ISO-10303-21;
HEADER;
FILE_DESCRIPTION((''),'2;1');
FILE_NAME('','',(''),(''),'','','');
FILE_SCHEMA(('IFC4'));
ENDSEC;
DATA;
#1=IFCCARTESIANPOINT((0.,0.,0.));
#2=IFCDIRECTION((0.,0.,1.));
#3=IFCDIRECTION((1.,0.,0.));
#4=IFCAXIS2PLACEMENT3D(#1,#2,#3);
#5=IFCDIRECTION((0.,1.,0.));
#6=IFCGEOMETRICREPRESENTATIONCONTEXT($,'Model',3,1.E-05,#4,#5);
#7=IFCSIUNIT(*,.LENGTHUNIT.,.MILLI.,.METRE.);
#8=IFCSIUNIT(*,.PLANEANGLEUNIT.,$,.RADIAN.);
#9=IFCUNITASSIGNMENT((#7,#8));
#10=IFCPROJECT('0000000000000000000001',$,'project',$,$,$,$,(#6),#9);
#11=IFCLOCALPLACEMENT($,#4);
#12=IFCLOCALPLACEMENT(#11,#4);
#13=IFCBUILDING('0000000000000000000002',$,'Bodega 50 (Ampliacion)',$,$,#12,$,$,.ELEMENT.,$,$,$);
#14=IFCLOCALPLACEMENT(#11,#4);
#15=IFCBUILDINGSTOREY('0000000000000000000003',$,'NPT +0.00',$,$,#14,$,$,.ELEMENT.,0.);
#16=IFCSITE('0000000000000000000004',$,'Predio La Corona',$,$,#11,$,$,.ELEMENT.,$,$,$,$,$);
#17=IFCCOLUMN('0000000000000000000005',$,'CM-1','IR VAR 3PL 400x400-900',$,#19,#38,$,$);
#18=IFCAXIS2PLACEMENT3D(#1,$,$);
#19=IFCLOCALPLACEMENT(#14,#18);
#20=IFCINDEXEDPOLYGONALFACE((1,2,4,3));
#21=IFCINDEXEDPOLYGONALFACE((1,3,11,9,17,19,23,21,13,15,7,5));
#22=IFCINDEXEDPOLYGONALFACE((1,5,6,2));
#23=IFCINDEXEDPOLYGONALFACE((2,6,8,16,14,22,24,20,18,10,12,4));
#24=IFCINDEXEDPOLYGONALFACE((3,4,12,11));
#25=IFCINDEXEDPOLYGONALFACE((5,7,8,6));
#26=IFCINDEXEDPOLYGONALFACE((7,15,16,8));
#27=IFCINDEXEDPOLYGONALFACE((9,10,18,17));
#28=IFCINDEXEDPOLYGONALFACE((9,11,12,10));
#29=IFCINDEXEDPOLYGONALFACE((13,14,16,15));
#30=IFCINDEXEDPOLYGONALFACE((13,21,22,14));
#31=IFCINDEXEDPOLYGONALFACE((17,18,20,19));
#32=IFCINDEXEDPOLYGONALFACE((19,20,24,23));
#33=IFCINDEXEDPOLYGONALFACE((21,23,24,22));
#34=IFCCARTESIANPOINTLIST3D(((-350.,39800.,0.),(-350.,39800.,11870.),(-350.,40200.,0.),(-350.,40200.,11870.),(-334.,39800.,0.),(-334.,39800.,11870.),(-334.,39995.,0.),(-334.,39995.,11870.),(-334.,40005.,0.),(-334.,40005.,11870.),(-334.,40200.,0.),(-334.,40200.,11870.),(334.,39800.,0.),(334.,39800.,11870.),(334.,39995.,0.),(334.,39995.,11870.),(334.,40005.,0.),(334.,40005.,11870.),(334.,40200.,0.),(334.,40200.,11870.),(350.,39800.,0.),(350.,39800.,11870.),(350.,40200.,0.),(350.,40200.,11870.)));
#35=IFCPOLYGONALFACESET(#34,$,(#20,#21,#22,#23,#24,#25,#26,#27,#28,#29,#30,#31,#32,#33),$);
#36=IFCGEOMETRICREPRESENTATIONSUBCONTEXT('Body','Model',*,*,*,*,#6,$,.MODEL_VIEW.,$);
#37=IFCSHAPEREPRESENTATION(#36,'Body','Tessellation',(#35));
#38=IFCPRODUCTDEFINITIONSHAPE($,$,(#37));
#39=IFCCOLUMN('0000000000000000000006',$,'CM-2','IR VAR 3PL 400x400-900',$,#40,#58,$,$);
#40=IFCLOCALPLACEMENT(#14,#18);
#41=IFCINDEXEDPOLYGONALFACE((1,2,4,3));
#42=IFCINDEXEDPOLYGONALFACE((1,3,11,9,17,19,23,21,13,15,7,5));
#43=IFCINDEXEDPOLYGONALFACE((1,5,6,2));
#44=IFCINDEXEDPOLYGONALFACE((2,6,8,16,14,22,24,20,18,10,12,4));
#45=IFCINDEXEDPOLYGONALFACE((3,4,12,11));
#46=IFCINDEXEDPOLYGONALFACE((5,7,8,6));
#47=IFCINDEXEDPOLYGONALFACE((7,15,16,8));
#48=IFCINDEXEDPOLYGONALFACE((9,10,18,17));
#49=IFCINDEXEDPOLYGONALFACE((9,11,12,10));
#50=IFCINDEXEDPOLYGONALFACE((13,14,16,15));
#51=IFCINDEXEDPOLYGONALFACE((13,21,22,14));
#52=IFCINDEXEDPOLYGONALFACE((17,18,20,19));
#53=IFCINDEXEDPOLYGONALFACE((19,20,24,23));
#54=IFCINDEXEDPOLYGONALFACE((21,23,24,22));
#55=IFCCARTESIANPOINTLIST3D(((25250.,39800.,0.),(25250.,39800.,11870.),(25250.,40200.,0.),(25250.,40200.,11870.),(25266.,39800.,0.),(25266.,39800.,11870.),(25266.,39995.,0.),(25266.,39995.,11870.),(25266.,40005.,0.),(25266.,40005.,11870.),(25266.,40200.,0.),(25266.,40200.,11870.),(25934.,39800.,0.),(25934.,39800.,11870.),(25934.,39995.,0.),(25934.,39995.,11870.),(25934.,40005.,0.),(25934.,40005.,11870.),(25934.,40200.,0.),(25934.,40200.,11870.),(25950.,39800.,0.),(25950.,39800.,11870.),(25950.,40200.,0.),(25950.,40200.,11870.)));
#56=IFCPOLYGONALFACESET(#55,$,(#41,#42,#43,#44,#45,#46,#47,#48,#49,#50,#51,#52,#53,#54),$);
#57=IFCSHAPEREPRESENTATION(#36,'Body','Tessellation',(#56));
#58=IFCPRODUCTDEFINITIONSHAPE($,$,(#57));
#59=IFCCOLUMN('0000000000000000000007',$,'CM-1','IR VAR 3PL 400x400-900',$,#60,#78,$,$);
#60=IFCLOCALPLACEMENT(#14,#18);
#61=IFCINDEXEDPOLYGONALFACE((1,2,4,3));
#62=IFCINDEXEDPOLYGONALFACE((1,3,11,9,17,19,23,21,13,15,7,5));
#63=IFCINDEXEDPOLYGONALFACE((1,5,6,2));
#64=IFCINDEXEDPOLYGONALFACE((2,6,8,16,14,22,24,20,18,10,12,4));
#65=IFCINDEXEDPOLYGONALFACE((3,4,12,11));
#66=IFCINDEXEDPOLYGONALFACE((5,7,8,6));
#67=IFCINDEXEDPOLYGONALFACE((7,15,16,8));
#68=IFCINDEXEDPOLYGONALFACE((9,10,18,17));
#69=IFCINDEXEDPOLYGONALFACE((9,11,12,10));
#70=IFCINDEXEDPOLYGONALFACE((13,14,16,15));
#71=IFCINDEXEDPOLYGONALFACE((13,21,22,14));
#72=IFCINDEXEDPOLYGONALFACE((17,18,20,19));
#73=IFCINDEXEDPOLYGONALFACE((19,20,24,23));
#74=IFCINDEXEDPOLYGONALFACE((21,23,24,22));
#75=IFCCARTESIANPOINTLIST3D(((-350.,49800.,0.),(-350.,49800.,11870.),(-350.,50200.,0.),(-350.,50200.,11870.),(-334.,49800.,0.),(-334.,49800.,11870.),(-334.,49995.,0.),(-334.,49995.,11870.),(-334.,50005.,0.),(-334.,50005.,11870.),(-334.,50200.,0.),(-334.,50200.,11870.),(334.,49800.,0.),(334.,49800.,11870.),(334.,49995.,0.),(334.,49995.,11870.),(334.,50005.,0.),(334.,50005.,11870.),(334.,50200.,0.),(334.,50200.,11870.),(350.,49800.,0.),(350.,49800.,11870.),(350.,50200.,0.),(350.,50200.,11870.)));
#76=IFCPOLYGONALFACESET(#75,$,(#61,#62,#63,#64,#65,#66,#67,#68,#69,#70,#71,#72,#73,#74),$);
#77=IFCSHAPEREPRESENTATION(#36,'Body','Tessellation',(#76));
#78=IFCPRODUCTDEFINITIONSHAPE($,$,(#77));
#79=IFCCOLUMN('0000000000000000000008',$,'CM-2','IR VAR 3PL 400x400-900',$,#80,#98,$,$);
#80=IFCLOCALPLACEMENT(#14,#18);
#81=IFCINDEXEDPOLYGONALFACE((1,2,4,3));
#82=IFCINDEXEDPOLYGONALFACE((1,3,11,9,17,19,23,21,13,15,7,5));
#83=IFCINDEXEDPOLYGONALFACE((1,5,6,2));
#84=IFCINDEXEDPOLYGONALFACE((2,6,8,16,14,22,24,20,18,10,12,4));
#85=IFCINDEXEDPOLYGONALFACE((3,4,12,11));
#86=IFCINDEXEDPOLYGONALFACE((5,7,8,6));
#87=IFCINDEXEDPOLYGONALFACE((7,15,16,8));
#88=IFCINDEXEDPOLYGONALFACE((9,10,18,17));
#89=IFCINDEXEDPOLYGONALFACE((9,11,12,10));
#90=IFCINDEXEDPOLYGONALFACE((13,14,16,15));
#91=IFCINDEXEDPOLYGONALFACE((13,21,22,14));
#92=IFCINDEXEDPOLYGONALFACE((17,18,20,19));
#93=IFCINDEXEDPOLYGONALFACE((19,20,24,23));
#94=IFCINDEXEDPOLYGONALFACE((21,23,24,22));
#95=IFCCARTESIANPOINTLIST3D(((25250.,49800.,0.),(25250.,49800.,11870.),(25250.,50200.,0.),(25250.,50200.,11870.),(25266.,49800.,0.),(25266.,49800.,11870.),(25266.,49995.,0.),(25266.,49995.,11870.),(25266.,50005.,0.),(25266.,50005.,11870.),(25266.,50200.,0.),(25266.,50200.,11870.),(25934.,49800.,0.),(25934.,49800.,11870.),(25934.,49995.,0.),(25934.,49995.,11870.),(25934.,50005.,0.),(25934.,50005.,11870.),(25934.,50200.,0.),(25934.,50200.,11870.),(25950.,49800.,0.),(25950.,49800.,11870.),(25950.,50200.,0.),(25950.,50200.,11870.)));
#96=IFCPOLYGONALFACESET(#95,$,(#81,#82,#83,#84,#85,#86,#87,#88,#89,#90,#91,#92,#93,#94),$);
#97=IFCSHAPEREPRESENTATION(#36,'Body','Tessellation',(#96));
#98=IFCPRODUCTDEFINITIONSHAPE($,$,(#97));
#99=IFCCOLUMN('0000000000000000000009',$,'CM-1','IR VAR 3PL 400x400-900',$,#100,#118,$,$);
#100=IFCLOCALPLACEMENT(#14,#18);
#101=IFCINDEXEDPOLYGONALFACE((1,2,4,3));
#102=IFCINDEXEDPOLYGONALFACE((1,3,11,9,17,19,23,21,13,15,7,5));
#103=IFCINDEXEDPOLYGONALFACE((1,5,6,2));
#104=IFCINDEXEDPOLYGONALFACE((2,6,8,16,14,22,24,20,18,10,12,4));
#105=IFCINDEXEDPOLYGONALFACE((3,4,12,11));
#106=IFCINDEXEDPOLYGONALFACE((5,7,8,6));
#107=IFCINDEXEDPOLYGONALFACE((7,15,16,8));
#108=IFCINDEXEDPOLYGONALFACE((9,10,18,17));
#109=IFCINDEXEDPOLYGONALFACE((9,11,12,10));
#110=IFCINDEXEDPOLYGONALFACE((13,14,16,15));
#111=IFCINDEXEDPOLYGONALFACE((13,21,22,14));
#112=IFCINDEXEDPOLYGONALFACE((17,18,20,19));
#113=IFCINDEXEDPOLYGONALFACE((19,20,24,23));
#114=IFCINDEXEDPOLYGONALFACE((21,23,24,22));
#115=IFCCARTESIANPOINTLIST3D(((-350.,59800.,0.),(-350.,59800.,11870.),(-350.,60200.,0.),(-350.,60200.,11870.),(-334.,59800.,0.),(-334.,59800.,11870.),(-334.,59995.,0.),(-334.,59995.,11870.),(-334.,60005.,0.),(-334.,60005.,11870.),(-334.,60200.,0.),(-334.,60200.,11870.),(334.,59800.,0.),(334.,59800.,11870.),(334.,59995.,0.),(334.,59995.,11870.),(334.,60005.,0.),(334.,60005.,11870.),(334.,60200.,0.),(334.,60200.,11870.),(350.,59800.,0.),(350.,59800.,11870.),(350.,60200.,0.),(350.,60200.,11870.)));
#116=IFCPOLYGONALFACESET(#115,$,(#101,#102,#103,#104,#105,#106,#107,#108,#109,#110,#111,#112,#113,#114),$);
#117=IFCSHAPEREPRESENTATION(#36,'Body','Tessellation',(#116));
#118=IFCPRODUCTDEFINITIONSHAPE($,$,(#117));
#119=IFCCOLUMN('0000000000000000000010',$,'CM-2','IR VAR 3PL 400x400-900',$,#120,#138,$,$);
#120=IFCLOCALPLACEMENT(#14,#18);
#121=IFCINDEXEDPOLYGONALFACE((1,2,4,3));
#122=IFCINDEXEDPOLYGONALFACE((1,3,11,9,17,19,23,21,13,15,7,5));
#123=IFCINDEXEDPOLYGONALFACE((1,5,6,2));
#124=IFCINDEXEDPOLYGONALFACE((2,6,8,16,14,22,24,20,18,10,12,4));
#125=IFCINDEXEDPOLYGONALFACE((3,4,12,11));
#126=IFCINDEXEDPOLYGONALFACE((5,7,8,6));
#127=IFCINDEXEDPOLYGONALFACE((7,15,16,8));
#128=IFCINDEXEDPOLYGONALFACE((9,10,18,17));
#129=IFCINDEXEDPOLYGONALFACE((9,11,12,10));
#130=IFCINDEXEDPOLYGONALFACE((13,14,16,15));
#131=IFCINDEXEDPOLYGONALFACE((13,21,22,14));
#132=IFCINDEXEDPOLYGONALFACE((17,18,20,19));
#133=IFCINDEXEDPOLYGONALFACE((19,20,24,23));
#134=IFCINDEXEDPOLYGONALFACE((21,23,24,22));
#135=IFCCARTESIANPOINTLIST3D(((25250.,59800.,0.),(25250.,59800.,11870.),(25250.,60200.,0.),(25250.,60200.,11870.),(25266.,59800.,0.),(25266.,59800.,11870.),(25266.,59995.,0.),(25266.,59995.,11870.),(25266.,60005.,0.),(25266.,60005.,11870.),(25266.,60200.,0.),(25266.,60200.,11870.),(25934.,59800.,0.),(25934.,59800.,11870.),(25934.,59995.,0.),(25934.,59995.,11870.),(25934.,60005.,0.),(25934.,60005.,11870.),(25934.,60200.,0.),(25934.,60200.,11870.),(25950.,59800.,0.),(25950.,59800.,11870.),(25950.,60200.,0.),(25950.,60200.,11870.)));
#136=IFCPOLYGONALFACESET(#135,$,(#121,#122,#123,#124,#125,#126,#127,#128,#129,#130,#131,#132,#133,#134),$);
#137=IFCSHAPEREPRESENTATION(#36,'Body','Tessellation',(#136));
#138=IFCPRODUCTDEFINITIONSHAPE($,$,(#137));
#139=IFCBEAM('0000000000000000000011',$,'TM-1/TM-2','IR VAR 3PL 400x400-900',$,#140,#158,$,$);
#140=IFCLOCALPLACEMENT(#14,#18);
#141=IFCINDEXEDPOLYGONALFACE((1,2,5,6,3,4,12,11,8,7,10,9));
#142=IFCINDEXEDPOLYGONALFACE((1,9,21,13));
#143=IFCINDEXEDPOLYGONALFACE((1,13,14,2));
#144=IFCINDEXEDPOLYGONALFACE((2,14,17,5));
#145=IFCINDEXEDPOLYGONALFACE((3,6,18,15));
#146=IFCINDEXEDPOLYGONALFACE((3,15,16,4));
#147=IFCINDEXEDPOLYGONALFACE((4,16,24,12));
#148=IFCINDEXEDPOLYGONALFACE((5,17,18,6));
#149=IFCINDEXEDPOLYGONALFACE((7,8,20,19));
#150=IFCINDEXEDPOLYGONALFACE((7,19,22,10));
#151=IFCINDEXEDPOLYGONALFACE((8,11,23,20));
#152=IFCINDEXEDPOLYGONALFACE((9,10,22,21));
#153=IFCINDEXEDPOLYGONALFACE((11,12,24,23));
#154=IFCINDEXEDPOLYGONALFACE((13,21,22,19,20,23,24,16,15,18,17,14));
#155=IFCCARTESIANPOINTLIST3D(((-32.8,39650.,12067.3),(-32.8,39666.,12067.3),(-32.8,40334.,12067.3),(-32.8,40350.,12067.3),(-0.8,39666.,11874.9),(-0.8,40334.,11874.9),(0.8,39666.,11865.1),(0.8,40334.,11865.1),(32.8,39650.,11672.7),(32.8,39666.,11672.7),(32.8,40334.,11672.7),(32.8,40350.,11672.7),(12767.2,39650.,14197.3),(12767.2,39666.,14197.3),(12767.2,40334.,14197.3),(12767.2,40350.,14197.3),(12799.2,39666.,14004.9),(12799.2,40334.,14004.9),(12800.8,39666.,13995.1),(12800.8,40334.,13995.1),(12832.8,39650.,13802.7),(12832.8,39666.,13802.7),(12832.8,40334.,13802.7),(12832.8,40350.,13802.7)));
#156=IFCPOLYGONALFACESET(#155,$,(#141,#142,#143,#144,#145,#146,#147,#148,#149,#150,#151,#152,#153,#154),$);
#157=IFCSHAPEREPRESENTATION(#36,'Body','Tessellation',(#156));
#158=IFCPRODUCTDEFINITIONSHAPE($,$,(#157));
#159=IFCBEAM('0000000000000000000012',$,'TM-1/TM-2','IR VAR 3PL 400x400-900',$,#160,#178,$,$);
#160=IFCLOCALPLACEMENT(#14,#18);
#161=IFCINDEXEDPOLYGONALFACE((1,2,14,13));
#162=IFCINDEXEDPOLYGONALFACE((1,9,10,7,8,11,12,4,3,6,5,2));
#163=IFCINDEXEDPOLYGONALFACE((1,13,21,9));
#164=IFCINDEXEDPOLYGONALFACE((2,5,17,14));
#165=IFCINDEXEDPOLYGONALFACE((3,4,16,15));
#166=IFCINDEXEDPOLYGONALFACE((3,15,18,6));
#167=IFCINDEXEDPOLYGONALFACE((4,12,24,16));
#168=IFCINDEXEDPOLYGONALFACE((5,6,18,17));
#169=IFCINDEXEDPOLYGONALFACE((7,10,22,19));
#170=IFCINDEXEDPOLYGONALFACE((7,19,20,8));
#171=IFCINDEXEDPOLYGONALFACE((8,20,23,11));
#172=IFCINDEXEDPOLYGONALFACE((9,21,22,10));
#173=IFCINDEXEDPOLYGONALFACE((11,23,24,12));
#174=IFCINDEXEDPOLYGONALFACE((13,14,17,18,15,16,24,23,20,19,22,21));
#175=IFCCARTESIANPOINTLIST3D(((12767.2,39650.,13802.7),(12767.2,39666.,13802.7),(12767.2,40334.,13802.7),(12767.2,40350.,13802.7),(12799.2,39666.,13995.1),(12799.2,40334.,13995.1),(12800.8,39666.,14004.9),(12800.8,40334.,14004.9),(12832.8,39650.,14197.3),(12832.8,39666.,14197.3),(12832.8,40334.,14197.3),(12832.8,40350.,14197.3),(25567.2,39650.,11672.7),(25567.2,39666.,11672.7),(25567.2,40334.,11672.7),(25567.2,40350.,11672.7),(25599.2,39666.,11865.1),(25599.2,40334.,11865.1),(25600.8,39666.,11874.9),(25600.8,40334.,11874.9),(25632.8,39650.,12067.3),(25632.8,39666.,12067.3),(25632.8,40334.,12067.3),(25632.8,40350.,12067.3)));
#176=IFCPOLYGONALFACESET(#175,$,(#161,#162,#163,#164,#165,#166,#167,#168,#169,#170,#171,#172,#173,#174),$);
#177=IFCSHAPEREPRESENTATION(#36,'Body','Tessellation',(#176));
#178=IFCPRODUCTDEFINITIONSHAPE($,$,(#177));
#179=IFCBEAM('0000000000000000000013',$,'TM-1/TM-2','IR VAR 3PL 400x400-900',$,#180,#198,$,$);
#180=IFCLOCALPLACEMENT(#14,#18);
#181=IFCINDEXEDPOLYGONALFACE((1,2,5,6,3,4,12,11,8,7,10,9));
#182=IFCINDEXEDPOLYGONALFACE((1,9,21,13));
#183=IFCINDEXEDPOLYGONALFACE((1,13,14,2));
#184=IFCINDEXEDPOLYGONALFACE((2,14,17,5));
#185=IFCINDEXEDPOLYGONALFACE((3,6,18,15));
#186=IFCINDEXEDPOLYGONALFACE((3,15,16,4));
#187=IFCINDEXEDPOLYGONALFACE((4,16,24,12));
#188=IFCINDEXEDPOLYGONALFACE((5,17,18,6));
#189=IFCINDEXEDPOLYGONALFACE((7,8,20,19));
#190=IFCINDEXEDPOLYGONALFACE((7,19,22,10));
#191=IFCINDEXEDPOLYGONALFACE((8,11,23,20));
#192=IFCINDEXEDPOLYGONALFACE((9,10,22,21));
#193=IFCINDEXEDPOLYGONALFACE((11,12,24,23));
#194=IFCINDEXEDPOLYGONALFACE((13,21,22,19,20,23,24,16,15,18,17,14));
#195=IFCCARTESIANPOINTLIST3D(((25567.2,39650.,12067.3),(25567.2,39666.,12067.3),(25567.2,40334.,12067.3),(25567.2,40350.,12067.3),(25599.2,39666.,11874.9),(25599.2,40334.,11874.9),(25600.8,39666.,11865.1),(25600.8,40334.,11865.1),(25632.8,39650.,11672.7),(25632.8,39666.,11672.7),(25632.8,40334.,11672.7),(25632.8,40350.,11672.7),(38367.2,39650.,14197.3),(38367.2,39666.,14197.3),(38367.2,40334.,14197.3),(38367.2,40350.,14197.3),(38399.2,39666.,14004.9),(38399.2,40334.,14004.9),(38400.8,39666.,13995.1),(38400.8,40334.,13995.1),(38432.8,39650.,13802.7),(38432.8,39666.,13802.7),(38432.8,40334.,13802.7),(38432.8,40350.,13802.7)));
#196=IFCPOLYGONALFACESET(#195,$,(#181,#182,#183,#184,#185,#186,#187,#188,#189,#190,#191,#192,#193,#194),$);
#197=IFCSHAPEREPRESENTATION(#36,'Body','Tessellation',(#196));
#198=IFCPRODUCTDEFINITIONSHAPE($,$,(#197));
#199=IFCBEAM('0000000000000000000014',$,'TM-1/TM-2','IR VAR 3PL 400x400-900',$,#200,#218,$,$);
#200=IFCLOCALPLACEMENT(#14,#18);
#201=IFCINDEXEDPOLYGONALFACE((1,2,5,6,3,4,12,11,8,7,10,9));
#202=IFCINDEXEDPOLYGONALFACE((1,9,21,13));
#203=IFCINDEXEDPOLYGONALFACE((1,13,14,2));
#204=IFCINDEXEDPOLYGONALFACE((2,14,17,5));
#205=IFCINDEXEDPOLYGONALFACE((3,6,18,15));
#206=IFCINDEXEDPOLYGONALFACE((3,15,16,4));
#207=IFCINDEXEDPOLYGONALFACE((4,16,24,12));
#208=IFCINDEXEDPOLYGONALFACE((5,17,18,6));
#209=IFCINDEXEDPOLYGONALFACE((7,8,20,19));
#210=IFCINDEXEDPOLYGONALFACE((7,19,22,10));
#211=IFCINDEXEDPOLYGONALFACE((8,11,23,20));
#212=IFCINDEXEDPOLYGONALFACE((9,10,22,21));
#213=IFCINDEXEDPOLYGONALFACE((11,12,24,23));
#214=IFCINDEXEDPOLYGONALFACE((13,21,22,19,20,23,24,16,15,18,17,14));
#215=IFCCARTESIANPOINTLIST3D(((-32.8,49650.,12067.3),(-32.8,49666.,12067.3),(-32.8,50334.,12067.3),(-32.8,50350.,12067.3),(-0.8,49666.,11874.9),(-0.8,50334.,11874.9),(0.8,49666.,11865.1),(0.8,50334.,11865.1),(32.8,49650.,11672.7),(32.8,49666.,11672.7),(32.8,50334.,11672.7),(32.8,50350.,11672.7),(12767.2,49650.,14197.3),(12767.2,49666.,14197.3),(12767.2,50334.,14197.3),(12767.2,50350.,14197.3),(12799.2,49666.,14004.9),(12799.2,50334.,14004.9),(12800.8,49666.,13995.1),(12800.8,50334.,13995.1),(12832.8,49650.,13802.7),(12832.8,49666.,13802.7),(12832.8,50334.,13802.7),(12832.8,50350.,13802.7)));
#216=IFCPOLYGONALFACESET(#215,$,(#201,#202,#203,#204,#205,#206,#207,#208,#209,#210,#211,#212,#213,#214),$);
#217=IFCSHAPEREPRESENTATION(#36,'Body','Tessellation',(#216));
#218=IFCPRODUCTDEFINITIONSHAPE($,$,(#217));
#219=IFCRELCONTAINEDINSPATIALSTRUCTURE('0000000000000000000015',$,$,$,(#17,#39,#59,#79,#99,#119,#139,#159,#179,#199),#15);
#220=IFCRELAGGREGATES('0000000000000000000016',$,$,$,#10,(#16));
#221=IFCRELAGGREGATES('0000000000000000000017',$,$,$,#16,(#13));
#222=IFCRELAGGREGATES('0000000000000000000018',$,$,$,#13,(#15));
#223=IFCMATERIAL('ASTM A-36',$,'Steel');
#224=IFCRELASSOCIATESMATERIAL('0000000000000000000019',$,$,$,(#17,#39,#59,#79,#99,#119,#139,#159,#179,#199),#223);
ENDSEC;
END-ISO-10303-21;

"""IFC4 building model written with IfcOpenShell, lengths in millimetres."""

from ifc_helpers import new_model, si_unit, direction, frame, origin_with_axes, origin_2d, place, context, subcontext, project, spatial, i_section, extrude, material, element, save


model = new_model("IFC4")

# Units and contexts
model_context = context("Model", 3, precision=1e-05, world=origin_with_axes(), true_north=direction((0.0, 1.0, 0.0)))
body_context = subcontext(model_context, "Body", "Model", "MODEL_VIEW")
ifc_project = project(units=[si_unit("LENGTHUNIT", "METRE", prefix="MILLI"), si_unit("PLANEANGLEUNIT", "RADIAN")], contexts=[model_context])

# Site, building, storey
site_placement = place(None, origin_with_axes())
site = spatial("IfcSite", under=ifc_project, at=site_placement, Name="Predio La Corona", CompositionType="ELEMENT")
building_placement = place(site_placement, origin_with_axes())
building = spatial("IfcBuilding", under=site, at=building_placement, Name="Bodega 50 (Ampliacion)", CompositionType="ELEMENT")
storey_placement = place(site_placement, origin_with_axes())
storey = spatial("IfcBuildingStorey", under=building, at=storey_placement, Name="NPT +0.00", CompositionType="ELEMENT", Elevation=0.0)

# Columns
ifc_material = material(Name="ASTM A-36", Category="Steel")
for number, where, z_axis, x_axis, name in (
    (1, (0.0, 40000.0, 0.0), (0.0, 0.0, 1.0), (0.0, -1.0, 0.0), "CM-1"),
    (2, (25600.0, 40000.0, 0.0), (0.0, 0.0, 1.0), (0.0, -1.0, 0.0), "CM-2"),
    (3, (0.0, 50000.0, 0.0), (0.0, 0.0, 1.0), (0.0, -1.0, 0.0), "CM-1"),
    (4, (25600.0, 50000.0, 0.0), (0.0, 0.0, 1.0), (0.0, -1.0, 0.0), "CM-2"),
    (5, (0.0, 60000.0, 0.0), (0.0, 0.0, 1.0), (0.0, -1.0, 0.0), "CM-1"),
    (6, (25600.0, 60000.0, 0.0), (0.0, 0.0, 1.0), (0.0, -1.0, 0.0), "CM-2"),
):
    element("IfcColumn", number, at=place(storey_placement, frame(where, z_axis=z_axis, x_axis=x_axis)), inside=storey, material=ifc_material, Name=name, Description="IR VAR 3PL 400x400-900", context=body_context, shape_type="SweptSolid", body=[
        extrude(i_section(OverallWidth=400.0, OverallDepth=700.0, WebThickness=10.0, FlangeThickness=16.0, at=origin_2d()), origin_with_axes(), (0.0, 0.0, 1.0), 11870.0),
    ])

# Beams
for number, where, z_axis, x_axis, name in (
    (7, (0.0, 40000.0, 11870.0), (0.986436, 0.0, 0.164149), (0.164149, 0.0, -0.986436), "TM-1/TM-2"),
    (8, (12800.0, 40000.0, 14000.0), (0.986436, 0.0, -0.164149), (-0.164149, 0.0, -0.986436), "TM-1/TM-2"),
    (9, (25600.0, 40000.0, 11870.0), (0.986436, 0.0, 0.164149), (0.164149, 0.0, -0.986436), "TM-1/TM-2"),
    (10, (0.0, 50000.0, 11870.0), (0.986436, 0.0, 0.164149), (0.164149, 0.0, -0.986436), "TM-1/TM-2"),
):
    element("IfcBeam", number, at=place(storey_placement, frame(where, z_axis=z_axis, x_axis=x_axis)), inside=storey, material=ifc_material, Name=name, Description="IR VAR 3PL 400x400-900", context=body_context, shape_type="SweptSolid", body=[
        extrude(i_section(OverallWidth=400.0, OverallDepth=700.0, WebThickness=10.0, FlangeThickness=16.0, at=origin_2d()), origin_with_axes(), (0.0, 0.0, 1.0), 12976.0),
    ])

save(model, "model.ifc")
